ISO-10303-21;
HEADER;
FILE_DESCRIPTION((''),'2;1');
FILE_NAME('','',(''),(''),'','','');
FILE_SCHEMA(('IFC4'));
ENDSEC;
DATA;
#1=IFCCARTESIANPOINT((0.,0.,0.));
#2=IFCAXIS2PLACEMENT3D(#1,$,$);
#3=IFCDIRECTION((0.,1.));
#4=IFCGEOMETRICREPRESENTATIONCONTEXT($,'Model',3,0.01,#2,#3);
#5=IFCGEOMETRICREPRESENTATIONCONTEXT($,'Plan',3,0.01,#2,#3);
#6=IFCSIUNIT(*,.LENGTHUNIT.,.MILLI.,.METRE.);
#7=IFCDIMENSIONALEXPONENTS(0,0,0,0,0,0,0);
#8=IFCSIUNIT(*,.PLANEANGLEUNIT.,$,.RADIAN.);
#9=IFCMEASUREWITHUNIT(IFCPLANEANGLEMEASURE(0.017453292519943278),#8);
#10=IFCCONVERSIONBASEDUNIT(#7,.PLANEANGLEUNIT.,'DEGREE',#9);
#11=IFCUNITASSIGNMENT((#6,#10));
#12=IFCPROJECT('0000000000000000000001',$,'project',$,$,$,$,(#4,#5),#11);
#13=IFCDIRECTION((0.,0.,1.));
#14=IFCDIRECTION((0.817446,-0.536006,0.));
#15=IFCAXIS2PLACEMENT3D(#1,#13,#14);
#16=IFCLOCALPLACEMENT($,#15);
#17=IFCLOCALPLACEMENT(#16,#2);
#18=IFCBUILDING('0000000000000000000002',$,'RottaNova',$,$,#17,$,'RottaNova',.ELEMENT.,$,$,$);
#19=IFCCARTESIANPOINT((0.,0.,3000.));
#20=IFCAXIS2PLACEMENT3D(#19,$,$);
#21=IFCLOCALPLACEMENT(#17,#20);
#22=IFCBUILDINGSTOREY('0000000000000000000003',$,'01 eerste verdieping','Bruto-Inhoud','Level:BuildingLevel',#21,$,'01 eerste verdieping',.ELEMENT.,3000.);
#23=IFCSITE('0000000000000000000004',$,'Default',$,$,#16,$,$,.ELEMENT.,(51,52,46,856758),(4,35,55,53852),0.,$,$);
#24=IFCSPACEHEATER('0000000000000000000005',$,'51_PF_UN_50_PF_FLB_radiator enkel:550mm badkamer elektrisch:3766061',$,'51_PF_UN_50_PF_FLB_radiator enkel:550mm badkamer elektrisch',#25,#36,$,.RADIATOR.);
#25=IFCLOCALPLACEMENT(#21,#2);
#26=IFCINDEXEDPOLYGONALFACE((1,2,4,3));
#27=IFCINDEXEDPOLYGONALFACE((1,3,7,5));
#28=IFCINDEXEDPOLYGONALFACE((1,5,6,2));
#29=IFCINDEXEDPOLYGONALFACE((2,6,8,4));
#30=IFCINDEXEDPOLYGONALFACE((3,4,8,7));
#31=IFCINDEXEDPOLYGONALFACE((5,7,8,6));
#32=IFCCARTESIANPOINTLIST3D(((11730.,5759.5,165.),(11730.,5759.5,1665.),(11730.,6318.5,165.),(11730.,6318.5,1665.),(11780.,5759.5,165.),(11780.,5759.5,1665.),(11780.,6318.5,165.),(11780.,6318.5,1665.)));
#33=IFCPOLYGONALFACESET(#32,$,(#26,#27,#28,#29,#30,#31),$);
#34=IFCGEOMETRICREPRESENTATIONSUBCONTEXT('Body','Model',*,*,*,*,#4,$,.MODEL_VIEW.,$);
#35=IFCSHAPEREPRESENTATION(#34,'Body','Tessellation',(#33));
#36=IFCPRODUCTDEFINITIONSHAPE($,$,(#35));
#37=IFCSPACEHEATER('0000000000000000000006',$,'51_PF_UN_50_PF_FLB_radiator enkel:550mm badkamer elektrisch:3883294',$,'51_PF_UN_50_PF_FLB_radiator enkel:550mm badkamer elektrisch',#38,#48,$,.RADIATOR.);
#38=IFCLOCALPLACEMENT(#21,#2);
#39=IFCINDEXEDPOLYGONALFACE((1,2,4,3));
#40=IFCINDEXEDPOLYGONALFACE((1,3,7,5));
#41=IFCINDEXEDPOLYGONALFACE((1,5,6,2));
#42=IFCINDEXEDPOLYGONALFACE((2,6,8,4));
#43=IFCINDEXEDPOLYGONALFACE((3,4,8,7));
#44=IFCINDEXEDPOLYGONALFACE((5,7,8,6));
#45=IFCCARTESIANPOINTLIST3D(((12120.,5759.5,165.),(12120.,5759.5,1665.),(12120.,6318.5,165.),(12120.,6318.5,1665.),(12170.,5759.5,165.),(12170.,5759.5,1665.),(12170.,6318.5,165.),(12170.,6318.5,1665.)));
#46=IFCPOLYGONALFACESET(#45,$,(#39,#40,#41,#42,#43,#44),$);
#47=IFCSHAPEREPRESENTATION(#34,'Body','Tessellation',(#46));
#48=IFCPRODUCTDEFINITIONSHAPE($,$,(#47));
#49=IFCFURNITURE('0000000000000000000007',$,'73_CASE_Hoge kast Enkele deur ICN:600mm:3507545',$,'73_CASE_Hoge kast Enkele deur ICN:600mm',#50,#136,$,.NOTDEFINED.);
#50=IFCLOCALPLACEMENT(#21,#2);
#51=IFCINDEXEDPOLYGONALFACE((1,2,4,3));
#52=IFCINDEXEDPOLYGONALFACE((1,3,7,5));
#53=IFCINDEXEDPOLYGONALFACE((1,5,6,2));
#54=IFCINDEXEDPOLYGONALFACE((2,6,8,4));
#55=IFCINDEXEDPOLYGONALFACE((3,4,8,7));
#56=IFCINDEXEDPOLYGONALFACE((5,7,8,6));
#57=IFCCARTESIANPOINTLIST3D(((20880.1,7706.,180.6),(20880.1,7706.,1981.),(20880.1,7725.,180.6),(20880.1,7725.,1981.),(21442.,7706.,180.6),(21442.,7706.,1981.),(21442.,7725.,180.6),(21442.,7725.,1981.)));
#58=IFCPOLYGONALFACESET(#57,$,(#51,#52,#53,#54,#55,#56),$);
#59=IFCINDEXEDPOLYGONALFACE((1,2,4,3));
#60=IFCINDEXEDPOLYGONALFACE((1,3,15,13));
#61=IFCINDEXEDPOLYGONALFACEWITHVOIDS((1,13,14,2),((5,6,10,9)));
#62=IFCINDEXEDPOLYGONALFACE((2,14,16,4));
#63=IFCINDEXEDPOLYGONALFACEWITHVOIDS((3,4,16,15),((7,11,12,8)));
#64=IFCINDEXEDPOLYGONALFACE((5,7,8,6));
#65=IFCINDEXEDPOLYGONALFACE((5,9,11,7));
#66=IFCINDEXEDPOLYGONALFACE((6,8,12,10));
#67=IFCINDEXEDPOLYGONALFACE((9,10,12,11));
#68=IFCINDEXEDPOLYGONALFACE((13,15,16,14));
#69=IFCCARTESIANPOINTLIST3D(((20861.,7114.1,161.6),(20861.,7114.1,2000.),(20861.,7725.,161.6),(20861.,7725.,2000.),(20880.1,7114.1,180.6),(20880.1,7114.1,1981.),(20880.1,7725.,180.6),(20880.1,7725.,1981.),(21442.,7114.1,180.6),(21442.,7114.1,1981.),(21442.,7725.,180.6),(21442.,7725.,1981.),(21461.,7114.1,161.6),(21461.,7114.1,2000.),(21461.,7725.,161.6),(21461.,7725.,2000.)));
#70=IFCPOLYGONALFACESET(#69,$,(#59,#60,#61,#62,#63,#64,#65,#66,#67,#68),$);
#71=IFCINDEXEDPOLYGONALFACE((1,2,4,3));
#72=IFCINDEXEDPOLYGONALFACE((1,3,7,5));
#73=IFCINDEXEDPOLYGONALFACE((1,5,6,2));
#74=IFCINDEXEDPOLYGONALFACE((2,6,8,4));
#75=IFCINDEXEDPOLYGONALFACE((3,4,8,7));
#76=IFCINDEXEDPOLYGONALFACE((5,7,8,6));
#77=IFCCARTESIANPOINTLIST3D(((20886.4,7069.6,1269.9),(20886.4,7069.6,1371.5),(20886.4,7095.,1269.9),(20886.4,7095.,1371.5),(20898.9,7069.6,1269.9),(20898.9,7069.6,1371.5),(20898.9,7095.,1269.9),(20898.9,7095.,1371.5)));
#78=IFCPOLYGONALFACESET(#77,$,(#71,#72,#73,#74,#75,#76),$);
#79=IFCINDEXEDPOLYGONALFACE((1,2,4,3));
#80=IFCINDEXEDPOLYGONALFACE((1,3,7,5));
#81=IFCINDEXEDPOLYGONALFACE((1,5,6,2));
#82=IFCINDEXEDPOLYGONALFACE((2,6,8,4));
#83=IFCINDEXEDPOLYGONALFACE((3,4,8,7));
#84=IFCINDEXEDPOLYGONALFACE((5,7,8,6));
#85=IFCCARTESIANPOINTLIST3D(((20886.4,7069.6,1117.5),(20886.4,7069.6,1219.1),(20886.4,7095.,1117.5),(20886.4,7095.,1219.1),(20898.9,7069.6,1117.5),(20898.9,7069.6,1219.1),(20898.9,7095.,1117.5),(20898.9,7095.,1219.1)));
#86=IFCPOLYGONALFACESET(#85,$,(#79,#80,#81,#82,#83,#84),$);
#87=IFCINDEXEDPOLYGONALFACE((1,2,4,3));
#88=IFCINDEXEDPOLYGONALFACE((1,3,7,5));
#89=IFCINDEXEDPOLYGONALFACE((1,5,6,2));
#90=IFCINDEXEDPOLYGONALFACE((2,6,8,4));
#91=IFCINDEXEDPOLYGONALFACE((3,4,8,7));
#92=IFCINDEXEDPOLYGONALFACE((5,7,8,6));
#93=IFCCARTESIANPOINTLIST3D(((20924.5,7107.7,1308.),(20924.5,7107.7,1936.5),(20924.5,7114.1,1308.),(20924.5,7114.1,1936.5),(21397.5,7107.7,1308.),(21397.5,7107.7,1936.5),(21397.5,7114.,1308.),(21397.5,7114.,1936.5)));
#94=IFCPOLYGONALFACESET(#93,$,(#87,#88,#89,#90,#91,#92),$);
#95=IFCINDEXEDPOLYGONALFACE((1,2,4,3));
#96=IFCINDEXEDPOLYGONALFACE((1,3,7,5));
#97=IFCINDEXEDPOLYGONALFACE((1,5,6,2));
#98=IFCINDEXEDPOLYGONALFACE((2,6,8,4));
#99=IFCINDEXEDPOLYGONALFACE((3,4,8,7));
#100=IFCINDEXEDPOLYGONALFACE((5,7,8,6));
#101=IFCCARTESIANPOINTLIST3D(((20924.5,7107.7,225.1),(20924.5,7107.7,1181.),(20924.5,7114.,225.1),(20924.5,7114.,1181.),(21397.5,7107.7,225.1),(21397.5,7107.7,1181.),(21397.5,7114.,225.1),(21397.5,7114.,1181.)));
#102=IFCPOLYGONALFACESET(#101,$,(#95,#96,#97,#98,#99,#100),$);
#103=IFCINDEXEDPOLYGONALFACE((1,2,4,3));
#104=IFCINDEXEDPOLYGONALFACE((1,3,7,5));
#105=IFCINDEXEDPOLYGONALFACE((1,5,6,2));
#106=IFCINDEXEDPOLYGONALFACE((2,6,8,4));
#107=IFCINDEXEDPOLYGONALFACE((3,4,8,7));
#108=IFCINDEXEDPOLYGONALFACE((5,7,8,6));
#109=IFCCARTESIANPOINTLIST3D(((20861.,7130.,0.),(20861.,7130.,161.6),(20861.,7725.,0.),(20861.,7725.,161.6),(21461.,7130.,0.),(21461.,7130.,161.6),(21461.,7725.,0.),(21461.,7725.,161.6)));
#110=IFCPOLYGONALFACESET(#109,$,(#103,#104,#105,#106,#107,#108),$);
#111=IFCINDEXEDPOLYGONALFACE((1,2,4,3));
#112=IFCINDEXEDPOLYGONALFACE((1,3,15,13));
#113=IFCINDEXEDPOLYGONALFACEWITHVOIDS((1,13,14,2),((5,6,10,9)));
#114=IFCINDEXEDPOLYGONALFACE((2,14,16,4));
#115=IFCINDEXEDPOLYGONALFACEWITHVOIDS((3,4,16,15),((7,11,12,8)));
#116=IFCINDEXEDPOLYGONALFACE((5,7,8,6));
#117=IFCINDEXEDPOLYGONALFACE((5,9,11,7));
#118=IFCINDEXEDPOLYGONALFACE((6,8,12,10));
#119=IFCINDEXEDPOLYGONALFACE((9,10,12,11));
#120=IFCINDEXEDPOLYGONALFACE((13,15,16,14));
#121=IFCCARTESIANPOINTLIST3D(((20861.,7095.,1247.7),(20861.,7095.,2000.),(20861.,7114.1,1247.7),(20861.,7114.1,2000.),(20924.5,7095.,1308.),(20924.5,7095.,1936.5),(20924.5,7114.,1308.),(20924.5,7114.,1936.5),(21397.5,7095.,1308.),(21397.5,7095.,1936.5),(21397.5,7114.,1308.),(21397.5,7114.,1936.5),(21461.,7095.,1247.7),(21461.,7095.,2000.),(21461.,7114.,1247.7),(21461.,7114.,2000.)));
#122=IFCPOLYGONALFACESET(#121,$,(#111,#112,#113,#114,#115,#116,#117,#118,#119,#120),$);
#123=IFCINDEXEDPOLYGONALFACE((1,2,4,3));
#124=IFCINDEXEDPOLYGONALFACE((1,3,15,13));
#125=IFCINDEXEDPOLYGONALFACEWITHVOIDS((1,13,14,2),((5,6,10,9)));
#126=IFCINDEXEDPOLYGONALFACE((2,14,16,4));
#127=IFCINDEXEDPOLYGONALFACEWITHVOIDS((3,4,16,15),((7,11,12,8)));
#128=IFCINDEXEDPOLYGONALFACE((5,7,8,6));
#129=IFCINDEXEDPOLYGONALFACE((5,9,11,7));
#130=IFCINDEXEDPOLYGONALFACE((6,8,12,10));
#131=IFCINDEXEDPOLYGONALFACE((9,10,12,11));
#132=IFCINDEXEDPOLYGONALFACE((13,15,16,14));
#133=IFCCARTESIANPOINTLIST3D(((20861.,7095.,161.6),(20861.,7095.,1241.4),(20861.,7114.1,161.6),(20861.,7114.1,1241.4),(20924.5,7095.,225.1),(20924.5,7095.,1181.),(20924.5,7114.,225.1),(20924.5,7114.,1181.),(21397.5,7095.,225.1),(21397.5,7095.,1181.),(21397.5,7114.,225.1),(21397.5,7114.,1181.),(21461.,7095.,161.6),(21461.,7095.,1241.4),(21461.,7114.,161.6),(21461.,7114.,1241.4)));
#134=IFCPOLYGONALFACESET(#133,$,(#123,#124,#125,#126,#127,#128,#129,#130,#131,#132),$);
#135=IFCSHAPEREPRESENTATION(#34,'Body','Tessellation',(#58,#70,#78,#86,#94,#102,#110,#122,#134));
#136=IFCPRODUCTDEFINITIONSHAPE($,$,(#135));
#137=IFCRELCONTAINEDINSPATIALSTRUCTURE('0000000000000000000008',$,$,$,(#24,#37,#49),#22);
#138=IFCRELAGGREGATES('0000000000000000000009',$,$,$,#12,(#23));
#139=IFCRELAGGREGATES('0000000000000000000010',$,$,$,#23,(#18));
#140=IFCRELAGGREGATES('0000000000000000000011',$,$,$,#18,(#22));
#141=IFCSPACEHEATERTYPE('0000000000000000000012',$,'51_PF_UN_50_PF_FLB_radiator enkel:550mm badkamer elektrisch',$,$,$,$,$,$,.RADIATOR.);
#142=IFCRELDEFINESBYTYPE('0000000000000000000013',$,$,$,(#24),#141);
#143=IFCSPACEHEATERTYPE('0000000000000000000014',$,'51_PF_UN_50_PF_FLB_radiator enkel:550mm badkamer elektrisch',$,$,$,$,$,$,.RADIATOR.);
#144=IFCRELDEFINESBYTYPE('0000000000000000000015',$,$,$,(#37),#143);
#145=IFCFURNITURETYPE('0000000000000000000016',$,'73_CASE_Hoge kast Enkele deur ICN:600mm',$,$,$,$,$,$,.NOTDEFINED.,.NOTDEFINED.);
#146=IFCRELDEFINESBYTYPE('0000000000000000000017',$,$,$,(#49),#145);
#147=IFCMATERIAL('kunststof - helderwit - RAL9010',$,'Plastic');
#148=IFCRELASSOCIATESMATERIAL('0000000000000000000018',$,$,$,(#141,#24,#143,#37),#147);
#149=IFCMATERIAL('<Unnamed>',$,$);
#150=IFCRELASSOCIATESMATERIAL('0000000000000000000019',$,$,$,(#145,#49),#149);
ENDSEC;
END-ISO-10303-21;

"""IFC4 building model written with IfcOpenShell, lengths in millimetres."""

from ifc_helpers import new_model, entity, si_unit, converted_unit, direction, frame, origin, place, context, subcontext, project, spatial, indexed_curve, outline, extrude, source, transform, mapped, material, type_object, type_shapes, element, save


model = new_model("IFC4")

# Units and contexts
model_context = context("Model", 3, precision=0.01, world=origin(), true_north=direction((0.0, 1.0)))
plan_context = context("Plan", 3, precision=0.01, world=origin(), true_north=direction((0.0, 1.0)))
body_context = subcontext(model_context, "Body", "Model", "MODEL_VIEW")
ifc_project = project(units=[si_unit("LENGTHUNIT", "METRE", prefix="MILLI"), converted_unit("PLANEANGLEUNIT", "DEGREE", entity("IfcPlaneAngleMeasure", 0.017453292519943278), si_unit("PLANEANGLEUNIT", "RADIAN"), dimensions=[0, 0, 0, 0, 0, 0, 0])], contexts=[model_context, plan_context])

# Site, building, storey
site_placement = place(None, frame((0.0, 0.0, 0.0), z_axis=(0.0, 0.0, 1.0), x_axis=(0.817446, -0.536006, 0.0)))
site = spatial("IfcSite", under=ifc_project, at=site_placement, Name="Default", CompositionType="ELEMENT", RefLatitude=(51, 52, 46, 856758), RefLongitude=(4, 35, 55, 53852), RefElevation=0.0)
building_placement = place(site_placement, origin())
building = spatial("IfcBuilding", under=site, at=building_placement, Name="RottaNova", LongName="RottaNova", CompositionType="ELEMENT")
storey_placement = place(building_placement, frame((0.0, 0.0, 3000.0)))
storey = spatial("IfcBuildingStorey", under=building, at=storey_placement, Name="01 eerste verdieping", Description="Bruto-Inhoud", ObjectType="Level:BuildingLevel", LongName="01 eerste verdieping", CompositionType="ELEMENT", Elevation=3000.0)

# Space heaters
ifc_material_1 = material(Name="kunststof - helderwit - RAL9010", Category="Plastic")
space_heater_type_1 = type_object("IfcSpaceHeaterType", Name="51_PF_UN_50_PF_FLB_radiator enkel:550mm badkamer elektrisch", PredefinedType="RADIATOR", material=ifc_material_1)
shared_shape_1 = source(origin(), body_context, "Body", "SweptSolid", [
    extrude(outline(indexed_curve([(-279.5, -25.0), (279.5, -25.0), (279.5, 25.0), (-279.5, 25.0), (-279.5, -25.0)], self_intersect=False)), frame((0.0, 75.0, 150.0), z_axis=(0.0, 0.0, 1.0), x_axis=(-1.0, 0.0, 0.0)), (0.0, 0.0, 1.0), 1500.0),
])
type_shapes(space_heater_type_1, [shared_shape_1])
space_heater_1_placement = place(storey_placement, frame((11680.0, 6039.0, 15.0), z_axis=(0.0, 0.0, 1.0), x_axis=(0.0, -1.0, 0.0)))
element("IfcSpaceHeater", 1, at=space_heater_1_placement, inside=storey, type_object=space_heater_type_1, material=ifc_material_1, Name="51_PF_UN_50_PF_FLB_radiator enkel:550mm badkamer elektrisch:3766061", ObjectType="51_PF_UN_50_PF_FLB_radiator enkel:550mm badkamer elektrisch", PredefinedType="RADIATOR", context=body_context, shape_type="MappedRepresentation", body=[
    mapped(shared_shape_1, transform((0.0, 0.0, 0.0), scale=1.0)),
])
space_heater_type_2 = type_object("IfcSpaceHeaterType", Name="51_PF_UN_50_PF_FLB_radiator enkel:550mm badkamer elektrisch", PredefinedType="RADIATOR", material=ifc_material_1)
shared_shape_2 = source(origin(), body_context, "Body", "SweptSolid", [
    extrude(outline(indexed_curve([(-25.0, -279.5), (25.0, -279.5), (25.0, 279.5), (-25.0, 279.5), (-25.0, -279.5)], self_intersect=False)), frame((0.0, -75.0, 150.0), z_axis=(0.0, 0.0, 1.0), x_axis=(0.0, 1.0, 0.0)), (0.0, 0.0, 1.0), 1500.0),
])
type_shapes(space_heater_type_2, [shared_shape_2])
space_heater_2_placement = place(storey_placement, frame((12220.0, 6039.0, 15.0), z_axis=(0.0, 0.0, 1.0), x_axis=(0.0, -1.0, 0.0)))
element("IfcSpaceHeater", 2, at=space_heater_2_placement, inside=storey, type_object=space_heater_type_2, material=ifc_material_1, Name="51_PF_UN_50_PF_FLB_radiator enkel:550mm badkamer elektrisch:3883294", ObjectType="51_PF_UN_50_PF_FLB_radiator enkel:550mm badkamer elektrisch", PredefinedType="RADIATOR", context=body_context, shape_type="MappedRepresentation", body=[
    mapped(shared_shape_2, transform((0.0, 0.0, 0.0), scale=1.0)),
])

# Furniture
ifc_material_2 = material(Name="<Unnamed>")
furniture_type = type_object("IfcFurnitureType", Name="73_CASE_Hoge kast Enkele deur ICN:600mm", AssemblyPlace="NOTDEFINED", PredefinedType="NOTDEFINED", material=ifc_material_2)
shared_shape_3 = source(origin(), body_context, "Body", "SweptSolid", [
    extrude(outline(indexed_curve([(-280.9, -9.5), (280.9, -9.5), (280.9, 9.5), (-280.9, 9.5), (-280.9, -9.5)], self_intersect=False)), frame((18.7, 9.5, 180.6), z_axis=(0.0, 0.0, 1.0), x_axis=(-1.0, 0.0, 0.0)), (0.0, 0.0, 1.0), 1800.3),
    extrude(outline(indexed_curve([(-300.0, -919.2), (300.0, -919.2), (300.0, 919.2), (-300.0, 919.2), (-300.0, -919.2)], self_intersect=False), holes=[indexed_curve([(-280.9, 900.2), (281.0, 900.2), (281.0, -900.2), (-280.9, -900.2), (-280.9, 900.2)], self_intersect=False)]), frame((18.7, 0.0, 1080.8), z_axis=(0.0, 1.0, 0.0), x_axis=(-1.0, 0.0, 0.0)), (0.0, 0.0, 1.0), 610.9),
    extrude(outline(indexed_curve([(-6.3, -12.7), (6.3, -12.7), (6.3, 12.7), (-6.3, 12.7), (-6.3, -12.7)], self_intersect=False)), frame((287.1, 642.7, 1269.9), z_axis=(0.0, 0.0, 1.0), x_axis=(-1.0, 0.0, 0.0)), (0.0, 0.0, 1.0), 101.6),
    extrude(outline(indexed_curve([(-6.3, -12.7), (6.3, -12.7), (6.3, 12.7), (-6.3, 12.7), (-6.3, -12.7)], self_intersect=False)), frame((287.1, 642.7, 1117.5), z_axis=(0.0, 0.0, 1.0), x_axis=(-1.0, 0.0, 0.0)), (0.0, 0.0, 1.0), 101.6),
    extrude(outline(indexed_curve([(-236.5, -3.2), (236.5, -3.2), (236.5, 3.2), (-236.5, 3.2), (-236.5, -3.2)], self_intersect=False)), frame((18.7, 614.1, 1308.0), z_axis=(0.0, 0.0, 1.0), x_axis=(-1.0, 0.0, 0.0)), (0.0, 0.0, 1.0), 628.5),
    extrude(outline(indexed_curve([(-236.5, -3.2), (236.5, -3.2), (236.5, 3.2), (-236.5, 3.2), (-236.5, -3.2)], self_intersect=False)), frame((18.7, 614.1, 225.1), z_axis=(0.0, 0.0, 1.0), x_axis=(-1.0, 0.0, 0.0)), (0.0, 0.0, 1.0), 956.0),
    extrude(outline(indexed_curve([(-297.5, -300.0), (297.5, -300.0), (297.5, 300.0), (-297.5, 300.0), (-297.5, -300.0)], self_intersect=False)), frame((18.7, 297.5, 0.0), z_axis=(0.0, 0.0, 1.0), x_axis=(0.0, 1.0, 0.0)), (0.0, 0.0, 1.0), 161.6),
    extrude(outline(indexed_curve([(-376.1, -300.0), (376.1, -300.0), (376.1, 300.0), (-376.1, 300.0), (-376.1, -300.0)], self_intersect=False), holes=[indexed_curve([(-312.6, -236.5), (-312.6, 236.5), (315.8, 236.5), (315.8, -236.5), (-312.6, -236.5)], self_intersect=False)]), frame((18.7, 610.9, 1623.9), z_axis=(0.0, 1.0, 0.0), x_axis=(0.0, 0.0, -1.0)), (0.0, 0.0, 1.0), 19.1),
    extrude(outline(indexed_curve([(-300.0, -539.9), (300.0, -539.9), (300.0, 539.9), (-300.0, 539.9), (-300.0, -539.9)], self_intersect=False), holes=[indexed_curve([(-236.5, 479.6), (236.5, 479.6), (236.5, -476.4), (-236.5, -476.4), (-236.5, 479.6)], self_intersect=False)]), frame((18.7, 610.9, 701.5), z_axis=(0.0, 1.0, 0.0), x_axis=(-1.0, 0.0, 0.0)), (0.0, 0.0, 1.0), 19.1),
])
type_shapes(furniture_type, [shared_shape_3])
for number, where, z_axis, x_axis, name in (
    (3, (21179.7, 7725.0, 0.0), (0.0, 0.0, 1.0), (-1.0, 0.0, 0.0), "73_CASE_Hoge kast Enkele deur ICN:600mm:3507545"),
):
    element("IfcFurniture", number, at=place(storey_placement, frame(where, z_axis=z_axis, x_axis=x_axis)), inside=storey, type_object=furniture_type, material=ifc_material_2, Name=name, ObjectType="73_CASE_Hoge kast Enkele deur ICN:600mm", PredefinedType="NOTDEFINED", context=body_context, shape_type="MappedRepresentation", body=[
        mapped(shared_shape_3, transform((0.0, 0.0, 0.0), scale=1.0)),
    ])

save(model, "model.ifc")
